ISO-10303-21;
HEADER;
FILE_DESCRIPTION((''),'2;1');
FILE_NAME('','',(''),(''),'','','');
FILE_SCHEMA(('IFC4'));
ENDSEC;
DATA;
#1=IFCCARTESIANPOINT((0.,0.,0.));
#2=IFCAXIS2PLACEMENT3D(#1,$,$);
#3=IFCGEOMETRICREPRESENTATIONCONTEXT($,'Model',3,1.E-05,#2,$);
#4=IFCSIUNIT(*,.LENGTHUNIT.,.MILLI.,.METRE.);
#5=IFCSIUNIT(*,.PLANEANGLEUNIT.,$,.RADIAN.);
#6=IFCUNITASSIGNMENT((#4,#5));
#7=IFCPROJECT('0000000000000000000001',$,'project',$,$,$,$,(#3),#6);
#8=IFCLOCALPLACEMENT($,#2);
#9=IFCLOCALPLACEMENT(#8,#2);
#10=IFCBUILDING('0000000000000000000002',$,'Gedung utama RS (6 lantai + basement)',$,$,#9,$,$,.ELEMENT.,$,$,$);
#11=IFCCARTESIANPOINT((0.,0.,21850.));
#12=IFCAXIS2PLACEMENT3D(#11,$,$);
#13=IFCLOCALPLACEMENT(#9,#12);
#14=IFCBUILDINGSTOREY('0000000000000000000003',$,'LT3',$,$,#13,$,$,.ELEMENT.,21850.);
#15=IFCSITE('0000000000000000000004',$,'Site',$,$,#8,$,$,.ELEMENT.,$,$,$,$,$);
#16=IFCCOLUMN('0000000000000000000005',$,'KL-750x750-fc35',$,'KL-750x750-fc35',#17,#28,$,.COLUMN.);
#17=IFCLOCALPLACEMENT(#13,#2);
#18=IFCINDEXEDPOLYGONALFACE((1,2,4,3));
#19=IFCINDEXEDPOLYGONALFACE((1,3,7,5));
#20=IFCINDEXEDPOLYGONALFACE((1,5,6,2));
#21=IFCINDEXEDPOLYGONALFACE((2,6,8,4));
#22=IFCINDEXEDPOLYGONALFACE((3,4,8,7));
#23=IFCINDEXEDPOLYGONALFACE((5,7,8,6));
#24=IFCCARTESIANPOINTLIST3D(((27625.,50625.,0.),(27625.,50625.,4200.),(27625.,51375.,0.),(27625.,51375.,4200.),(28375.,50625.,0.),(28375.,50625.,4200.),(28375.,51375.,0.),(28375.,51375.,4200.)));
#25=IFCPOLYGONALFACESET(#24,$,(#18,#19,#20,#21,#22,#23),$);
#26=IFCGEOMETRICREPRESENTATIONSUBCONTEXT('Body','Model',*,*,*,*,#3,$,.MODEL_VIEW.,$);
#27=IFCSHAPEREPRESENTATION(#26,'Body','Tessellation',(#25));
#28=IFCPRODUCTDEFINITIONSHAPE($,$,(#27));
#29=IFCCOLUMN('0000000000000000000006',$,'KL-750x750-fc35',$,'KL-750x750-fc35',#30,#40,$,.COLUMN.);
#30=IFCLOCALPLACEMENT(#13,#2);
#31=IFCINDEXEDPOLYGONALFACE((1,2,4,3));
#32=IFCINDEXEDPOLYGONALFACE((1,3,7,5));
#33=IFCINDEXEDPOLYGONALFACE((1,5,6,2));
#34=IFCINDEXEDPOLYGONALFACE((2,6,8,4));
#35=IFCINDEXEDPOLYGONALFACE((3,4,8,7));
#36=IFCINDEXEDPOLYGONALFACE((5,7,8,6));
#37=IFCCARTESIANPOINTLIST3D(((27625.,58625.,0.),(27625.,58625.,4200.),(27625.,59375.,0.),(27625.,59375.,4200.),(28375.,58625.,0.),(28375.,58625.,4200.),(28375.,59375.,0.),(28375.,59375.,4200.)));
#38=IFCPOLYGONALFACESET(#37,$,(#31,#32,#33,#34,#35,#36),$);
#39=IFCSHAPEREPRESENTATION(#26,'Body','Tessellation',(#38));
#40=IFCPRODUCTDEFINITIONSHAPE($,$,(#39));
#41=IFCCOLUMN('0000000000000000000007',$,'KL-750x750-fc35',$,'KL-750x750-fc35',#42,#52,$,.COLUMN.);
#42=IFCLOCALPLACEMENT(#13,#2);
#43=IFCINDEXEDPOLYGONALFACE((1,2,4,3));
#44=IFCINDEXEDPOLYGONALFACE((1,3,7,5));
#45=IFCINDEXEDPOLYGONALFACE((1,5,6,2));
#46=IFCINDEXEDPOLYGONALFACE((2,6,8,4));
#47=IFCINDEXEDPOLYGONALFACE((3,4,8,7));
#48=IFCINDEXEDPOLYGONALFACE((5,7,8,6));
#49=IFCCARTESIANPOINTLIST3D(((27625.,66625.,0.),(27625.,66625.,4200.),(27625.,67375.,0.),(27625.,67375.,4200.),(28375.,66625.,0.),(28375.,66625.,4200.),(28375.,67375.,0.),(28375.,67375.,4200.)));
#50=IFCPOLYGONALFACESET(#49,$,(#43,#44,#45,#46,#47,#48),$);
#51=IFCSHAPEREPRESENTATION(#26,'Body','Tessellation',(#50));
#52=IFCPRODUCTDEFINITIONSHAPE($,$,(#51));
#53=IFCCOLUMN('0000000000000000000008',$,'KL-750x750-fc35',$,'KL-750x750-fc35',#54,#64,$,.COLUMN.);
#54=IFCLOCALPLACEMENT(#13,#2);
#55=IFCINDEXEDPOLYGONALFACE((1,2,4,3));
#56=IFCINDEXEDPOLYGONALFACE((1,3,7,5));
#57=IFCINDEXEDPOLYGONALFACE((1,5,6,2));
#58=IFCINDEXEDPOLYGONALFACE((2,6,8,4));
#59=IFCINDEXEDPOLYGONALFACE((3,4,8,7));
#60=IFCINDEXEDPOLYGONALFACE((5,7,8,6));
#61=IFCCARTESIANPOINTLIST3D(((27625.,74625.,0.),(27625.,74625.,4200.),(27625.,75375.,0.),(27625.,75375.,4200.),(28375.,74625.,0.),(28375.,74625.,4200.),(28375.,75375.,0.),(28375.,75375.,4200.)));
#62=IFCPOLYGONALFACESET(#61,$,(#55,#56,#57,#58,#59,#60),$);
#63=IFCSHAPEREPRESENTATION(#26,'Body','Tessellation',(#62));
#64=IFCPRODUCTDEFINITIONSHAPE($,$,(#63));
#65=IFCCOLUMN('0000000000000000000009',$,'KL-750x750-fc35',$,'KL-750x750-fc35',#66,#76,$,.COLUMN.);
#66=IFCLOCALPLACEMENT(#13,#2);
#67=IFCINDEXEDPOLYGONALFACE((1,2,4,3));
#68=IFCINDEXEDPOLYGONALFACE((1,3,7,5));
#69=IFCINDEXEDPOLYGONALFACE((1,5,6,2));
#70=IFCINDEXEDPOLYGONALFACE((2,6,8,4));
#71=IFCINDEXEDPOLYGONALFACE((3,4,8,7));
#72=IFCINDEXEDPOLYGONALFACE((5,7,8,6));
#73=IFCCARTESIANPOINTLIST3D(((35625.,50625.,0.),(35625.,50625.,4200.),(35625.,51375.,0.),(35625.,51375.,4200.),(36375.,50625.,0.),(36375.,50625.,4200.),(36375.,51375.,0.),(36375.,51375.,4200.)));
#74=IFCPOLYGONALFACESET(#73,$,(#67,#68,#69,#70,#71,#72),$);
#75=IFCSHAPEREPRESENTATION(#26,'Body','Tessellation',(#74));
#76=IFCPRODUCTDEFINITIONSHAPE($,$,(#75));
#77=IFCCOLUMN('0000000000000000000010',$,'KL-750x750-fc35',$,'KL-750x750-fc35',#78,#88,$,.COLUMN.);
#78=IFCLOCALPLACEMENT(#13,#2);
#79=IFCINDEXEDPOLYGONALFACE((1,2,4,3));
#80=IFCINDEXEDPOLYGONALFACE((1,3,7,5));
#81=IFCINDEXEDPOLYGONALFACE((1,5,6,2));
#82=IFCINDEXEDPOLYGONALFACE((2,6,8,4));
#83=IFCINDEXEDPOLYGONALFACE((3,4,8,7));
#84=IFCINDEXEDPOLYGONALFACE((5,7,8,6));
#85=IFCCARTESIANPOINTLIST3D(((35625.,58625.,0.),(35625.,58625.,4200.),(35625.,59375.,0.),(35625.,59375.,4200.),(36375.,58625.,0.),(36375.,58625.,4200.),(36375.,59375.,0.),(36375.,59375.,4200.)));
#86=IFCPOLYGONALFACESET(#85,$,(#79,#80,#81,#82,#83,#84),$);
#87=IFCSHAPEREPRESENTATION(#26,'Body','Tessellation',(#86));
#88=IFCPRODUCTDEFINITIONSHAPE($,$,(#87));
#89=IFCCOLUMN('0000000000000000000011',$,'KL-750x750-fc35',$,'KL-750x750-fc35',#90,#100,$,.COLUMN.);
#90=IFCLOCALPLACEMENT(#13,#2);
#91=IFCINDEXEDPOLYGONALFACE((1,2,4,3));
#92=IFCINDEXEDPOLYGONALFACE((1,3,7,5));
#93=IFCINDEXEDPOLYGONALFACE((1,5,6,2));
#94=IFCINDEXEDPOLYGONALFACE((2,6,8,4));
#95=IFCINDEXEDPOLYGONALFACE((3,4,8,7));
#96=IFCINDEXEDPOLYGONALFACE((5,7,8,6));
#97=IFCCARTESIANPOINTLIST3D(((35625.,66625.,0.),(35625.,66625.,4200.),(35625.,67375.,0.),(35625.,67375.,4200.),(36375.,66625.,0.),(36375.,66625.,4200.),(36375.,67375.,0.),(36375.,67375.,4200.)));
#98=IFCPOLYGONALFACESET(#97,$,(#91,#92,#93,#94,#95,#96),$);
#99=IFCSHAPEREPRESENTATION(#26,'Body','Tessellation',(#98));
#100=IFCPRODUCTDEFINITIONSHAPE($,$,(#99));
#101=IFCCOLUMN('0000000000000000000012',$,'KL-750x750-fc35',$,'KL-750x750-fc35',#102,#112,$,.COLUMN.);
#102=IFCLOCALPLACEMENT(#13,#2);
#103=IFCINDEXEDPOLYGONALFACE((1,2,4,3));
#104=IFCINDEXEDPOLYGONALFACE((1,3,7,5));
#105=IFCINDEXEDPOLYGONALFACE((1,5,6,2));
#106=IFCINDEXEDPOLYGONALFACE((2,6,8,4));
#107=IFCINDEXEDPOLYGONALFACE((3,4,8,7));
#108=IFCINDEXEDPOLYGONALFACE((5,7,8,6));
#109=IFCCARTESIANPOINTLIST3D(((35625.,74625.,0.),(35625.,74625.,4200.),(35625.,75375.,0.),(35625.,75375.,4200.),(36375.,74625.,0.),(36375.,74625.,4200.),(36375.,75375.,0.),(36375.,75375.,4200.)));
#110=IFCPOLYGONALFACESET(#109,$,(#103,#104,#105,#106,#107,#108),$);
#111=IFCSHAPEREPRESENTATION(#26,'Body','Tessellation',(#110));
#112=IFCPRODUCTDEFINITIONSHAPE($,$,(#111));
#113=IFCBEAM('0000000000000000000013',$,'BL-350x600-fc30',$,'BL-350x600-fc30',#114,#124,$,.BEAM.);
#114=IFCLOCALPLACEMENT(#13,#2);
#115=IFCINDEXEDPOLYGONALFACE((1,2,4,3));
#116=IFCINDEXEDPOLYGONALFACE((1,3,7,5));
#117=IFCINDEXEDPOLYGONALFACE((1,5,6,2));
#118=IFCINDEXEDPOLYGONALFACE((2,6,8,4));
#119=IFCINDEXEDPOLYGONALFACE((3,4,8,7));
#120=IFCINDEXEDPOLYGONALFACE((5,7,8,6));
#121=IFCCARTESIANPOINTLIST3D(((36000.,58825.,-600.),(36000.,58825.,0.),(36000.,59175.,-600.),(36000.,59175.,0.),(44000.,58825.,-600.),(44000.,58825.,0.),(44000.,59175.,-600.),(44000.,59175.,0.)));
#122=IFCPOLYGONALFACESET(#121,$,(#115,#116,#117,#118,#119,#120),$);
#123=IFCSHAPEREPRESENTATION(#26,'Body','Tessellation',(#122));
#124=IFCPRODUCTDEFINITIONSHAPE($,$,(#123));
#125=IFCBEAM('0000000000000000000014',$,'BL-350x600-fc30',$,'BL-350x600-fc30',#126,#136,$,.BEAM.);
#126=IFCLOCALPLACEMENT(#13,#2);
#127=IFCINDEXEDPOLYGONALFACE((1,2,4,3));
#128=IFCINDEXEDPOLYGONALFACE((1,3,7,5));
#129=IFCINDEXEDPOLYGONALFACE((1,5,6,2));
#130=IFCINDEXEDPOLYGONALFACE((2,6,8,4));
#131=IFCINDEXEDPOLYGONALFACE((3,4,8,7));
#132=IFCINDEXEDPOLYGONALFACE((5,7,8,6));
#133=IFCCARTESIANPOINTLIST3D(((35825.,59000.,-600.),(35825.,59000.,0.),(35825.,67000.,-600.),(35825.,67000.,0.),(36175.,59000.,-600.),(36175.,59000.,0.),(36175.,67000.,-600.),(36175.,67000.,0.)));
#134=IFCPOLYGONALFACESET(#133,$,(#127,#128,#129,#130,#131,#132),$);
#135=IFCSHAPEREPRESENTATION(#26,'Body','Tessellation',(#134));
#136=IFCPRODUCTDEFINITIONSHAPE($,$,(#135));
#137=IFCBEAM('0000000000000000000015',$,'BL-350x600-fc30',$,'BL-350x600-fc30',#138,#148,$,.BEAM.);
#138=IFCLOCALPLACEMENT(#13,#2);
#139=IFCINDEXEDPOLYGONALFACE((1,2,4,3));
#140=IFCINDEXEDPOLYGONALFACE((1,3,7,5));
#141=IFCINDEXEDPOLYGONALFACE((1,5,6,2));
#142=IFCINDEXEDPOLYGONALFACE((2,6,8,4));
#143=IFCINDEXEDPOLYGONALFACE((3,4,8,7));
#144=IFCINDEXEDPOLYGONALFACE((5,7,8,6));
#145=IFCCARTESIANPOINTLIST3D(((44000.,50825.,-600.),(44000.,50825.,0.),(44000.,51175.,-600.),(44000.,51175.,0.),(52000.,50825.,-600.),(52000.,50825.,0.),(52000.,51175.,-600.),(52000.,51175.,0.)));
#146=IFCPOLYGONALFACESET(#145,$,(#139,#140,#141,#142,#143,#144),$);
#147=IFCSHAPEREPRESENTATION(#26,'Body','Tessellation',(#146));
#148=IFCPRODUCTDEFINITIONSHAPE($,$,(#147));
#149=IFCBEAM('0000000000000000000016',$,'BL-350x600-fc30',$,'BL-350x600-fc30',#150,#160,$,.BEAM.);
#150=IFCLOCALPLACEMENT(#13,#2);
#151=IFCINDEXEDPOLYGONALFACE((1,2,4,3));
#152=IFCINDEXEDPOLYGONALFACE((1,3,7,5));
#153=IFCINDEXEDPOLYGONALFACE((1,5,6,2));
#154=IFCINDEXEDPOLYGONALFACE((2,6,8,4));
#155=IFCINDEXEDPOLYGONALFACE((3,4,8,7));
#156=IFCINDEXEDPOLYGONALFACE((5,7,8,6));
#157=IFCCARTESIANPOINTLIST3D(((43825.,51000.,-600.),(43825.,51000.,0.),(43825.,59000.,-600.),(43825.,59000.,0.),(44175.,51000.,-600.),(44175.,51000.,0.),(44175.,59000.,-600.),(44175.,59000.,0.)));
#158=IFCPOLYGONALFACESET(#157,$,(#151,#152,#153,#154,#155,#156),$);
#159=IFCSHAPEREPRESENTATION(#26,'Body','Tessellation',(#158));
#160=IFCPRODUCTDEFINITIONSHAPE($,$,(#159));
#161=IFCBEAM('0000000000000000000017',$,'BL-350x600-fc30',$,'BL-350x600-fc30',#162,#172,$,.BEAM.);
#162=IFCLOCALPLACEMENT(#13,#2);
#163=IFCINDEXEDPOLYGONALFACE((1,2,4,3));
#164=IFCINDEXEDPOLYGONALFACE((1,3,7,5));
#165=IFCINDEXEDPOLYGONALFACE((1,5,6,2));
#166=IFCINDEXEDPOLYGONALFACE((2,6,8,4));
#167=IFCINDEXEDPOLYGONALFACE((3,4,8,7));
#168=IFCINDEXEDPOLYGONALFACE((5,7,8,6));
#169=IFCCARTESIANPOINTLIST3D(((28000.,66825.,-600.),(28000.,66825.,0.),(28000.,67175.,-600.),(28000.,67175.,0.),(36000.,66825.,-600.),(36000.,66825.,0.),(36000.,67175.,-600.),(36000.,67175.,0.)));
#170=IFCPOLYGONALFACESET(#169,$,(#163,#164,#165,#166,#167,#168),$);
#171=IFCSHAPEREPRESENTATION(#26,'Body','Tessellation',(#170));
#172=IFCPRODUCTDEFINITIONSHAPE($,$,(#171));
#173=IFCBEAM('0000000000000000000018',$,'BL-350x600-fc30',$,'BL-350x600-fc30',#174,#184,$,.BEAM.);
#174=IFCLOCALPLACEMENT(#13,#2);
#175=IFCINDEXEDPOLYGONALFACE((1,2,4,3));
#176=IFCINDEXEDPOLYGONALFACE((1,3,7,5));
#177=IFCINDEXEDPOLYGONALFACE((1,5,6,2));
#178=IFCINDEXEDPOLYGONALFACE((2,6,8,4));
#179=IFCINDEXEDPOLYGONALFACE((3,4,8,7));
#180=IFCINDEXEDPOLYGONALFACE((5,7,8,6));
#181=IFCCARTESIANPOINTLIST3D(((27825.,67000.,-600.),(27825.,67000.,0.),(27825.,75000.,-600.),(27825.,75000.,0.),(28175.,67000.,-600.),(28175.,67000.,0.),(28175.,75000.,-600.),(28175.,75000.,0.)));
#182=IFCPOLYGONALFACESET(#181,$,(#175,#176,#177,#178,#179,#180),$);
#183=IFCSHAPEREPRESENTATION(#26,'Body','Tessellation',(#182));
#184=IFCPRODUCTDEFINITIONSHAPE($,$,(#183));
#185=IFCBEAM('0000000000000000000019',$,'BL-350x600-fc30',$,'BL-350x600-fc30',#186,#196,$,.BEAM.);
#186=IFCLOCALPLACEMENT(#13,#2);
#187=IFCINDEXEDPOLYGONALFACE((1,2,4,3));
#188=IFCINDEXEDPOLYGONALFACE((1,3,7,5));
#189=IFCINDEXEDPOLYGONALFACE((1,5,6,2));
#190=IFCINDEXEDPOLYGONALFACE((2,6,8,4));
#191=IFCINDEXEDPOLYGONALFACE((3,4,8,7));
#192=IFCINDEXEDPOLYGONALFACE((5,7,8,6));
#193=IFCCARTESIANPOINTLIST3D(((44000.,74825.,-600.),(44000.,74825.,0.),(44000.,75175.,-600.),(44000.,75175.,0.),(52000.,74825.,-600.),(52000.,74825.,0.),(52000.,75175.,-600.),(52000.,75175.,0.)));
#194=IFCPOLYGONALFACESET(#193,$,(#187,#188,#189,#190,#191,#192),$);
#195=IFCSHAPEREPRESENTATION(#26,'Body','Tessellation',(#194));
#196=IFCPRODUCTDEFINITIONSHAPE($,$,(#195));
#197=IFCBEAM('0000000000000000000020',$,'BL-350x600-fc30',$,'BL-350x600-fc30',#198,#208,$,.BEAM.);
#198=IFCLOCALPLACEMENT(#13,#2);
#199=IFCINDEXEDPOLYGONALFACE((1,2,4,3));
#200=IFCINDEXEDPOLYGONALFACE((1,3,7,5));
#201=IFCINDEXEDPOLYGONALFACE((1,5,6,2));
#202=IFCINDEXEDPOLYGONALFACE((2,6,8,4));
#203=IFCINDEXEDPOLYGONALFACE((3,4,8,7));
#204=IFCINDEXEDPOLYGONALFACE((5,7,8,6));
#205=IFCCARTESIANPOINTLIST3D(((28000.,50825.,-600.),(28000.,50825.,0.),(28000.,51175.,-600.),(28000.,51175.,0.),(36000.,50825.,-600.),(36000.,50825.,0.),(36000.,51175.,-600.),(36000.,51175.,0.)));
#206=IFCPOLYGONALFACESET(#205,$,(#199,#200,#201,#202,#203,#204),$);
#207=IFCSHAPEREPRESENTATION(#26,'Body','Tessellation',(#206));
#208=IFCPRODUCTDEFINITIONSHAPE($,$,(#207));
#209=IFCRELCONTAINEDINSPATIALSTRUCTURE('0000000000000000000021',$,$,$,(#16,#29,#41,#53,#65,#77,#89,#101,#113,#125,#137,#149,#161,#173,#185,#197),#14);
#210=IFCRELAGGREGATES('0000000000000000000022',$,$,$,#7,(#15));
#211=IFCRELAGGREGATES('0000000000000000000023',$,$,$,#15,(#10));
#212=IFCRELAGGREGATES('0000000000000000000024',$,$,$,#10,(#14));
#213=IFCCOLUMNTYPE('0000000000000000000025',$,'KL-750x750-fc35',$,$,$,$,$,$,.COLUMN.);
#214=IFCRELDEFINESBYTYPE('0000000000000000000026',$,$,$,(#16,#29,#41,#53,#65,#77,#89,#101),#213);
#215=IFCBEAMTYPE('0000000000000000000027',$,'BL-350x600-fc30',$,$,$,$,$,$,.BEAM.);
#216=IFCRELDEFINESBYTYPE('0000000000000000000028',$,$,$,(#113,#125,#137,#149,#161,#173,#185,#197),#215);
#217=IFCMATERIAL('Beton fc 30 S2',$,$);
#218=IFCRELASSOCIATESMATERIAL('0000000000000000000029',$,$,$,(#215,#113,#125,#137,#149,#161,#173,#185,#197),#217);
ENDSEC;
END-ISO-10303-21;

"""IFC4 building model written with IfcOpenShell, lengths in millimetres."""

from ifc_helpers import new_model, si_unit, frame, origin, origin_2d, place, context, subcontext, project, spatial, rectangle, extrude, material, material_profile, profile_set, profile_usage, type_object, element, save


model = new_model("IFC4")

# Units and contexts
model_context = context("Model", 3, precision=1e-05, world=origin())
body_context = subcontext(model_context, "Body", "Model", "MODEL_VIEW")
ifc_project = project(units=[si_unit("LENGTHUNIT", "METRE", prefix="MILLI"), si_unit("PLANEANGLEUNIT", "RADIAN")], contexts=[model_context])

# Site, building, storey
site_placement = place(None, origin())
site = spatial("IfcSite", under=ifc_project, at=site_placement, Name="Site", CompositionType="ELEMENT")
building_placement = place(site_placement, origin())
building = spatial("IfcBuilding", under=site, at=building_placement, Name="Gedung utama RS (6 lantai + basement)", CompositionType="ELEMENT")
storey_placement = place(building_placement, frame((0.0, 0.0, 21850.0)))
storey = spatial("IfcBuildingStorey", under=building, at=storey_placement, Name="LT3", CompositionType="ELEMENT", Elevation=21850.0)

# Columns
ifc_material_profile_1 = material_profile(None, rectangle(XDim=750.0, YDim=750.0, at=origin_2d()), Name="KL-750x750-fc35")
ifc_profile_set_1 = profile_set([ifc_material_profile_1], Name="KL-750x750-fc35")
ifc_profile_usage_1 = profile_usage(ifc_profile_set_1, cardinal=5)
column_type = type_object("IfcColumnType", Name="KL-750x750-fc35", PredefinedType="COLUMN", material=ifc_profile_set_1)
for number, where, z_axis, x_axis, name in (
    (1, (28000.0, 51000.0, 0.0), (0.0, 0.0, 1.0), (1.0, 0.0, 0.0), "KL-750x750-fc35"),
    (2, (28000.0, 59000.0, 0.0), (0.0, 0.0, 1.0), (1.0, 0.0, 0.0), "KL-750x750-fc35"),
    (3, (28000.0, 67000.0, 0.0), (0.0, 0.0, 1.0), (1.0, 0.0, 0.0), "KL-750x750-fc35"),
    (4, (28000.0, 75000.0, 0.0), (0.0, 0.0, 1.0), (1.0, 0.0, 0.0), "KL-750x750-fc35"),
    (5, (36000.0, 51000.0, 0.0), (0.0, 0.0, 1.0), (1.0, 0.0, 0.0), "KL-750x750-fc35"),
    (6, (36000.0, 59000.0, 0.0), (0.0, 0.0, 1.0), (1.0, 0.0, 0.0), "KL-750x750-fc35"),
    (7, (36000.0, 67000.0, 0.0), (0.0, 0.0, 1.0), (1.0, 0.0, 0.0), "KL-750x750-fc35"),
    (8, (36000.0, 75000.0, 0.0), (0.0, 0.0, 1.0), (1.0, 0.0, 0.0), "KL-750x750-fc35"),
):
    element("IfcColumn", number, at=place(storey_placement, frame(where, z_axis=z_axis, x_axis=x_axis)), inside=storey, type_object=column_type, material=ifc_profile_usage_1, Name=name, ObjectType="KL-750x750-fc35", PredefinedType="COLUMN", context=body_context, shape_type="SweptSolid", body=[
        extrude(rectangle(XDim=750.0, YDim=750.0, at=origin_2d()), origin(), (0.0, 0.0, 1.0), 4200.0),
    ])

# Beams
ifc_material = material(Name="Beton fc 30 S2")
ifc_material_profile_2 = material_profile(ifc_material, rectangle(XDim=350.0, YDim=600.0, at=origin_2d()), Name="BL-350x600-fc30")
ifc_profile_set_2 = profile_set([ifc_material_profile_2], Name="BL-350x600-fc30")
ifc_profile_usage_2 = profile_usage(ifc_profile_set_2, cardinal=8)
beam_type = type_object("IfcBeamType", Name="BL-350x600-fc30", PredefinedType="BEAM", material=ifc_profile_set_2)
beam_1_placement = place(storey_placement, frame((36000.0, 59000.0, -300.0)))
element("IfcBeam", 9, at=beam_1_placement, inside=storey, type_object=beam_type, material=ifc_profile_usage_2, Name="BL-350x600-fc30", ObjectType="BL-350x600-fc30", PredefinedType="BEAM", context=body_context, shape_type="SweptSolid", body=[
    extrude(rectangle(XDim=350.0, YDim=600.0, at=origin_2d()), frame((0.0, 0.0, 0.0), z_axis=(1.0, 0.0, 0.0), x_axis=(0.0, 1.0, 0.0)), (0.0, 0.0, 1.0), 8000.0),
])
beam_2_placement = place(storey_placement, frame((36000.0, 59000.0, -300.0)))
element("IfcBeam", 10, at=beam_2_placement, inside=storey, type_object=beam_type, material=ifc_profile_usage_2, Name="BL-350x600-fc30", ObjectType="BL-350x600-fc30", PredefinedType="BEAM", context=body_context, shape_type="SweptSolid", body=[
    extrude(rectangle(XDim=350.0, YDim=600.0, at=origin_2d()), frame((0.0, 0.0, 0.0), z_axis=(0.0, 1.0, 0.0), x_axis=(-1.0, 0.0, 0.0)), (0.0, 0.0, 1.0), 8000.0),
])
beam_3_placement = place(storey_placement, frame((44000.0, 51000.0, -300.0)))
element("IfcBeam", 11, at=beam_3_placement, inside=storey, type_object=beam_type, material=ifc_profile_usage_2, Name="BL-350x600-fc30", ObjectType="BL-350x600-fc30", PredefinedType="BEAM", context=body_context, shape_type="SweptSolid", body=[
    extrude(rectangle(XDim=350.0, YDim=600.0, at=origin_2d()), frame((0.0, 0.0, 0.0), z_axis=(1.0, 0.0, 0.0), x_axis=(0.0, 1.0, 0.0)), (0.0, 0.0, 1.0), 8000.0),
])
beam_4_placement = place(storey_placement, frame((44000.0, 51000.0, -300.0)))
element("IfcBeam", 12, at=beam_4_placement, inside=storey, type_object=beam_type, material=ifc_profile_usage_2, Name="BL-350x600-fc30", ObjectType="BL-350x600-fc30", PredefinedType="BEAM", context=body_context, shape_type="SweptSolid", body=[
    extrude(rectangle(XDim=350.0, YDim=600.0, at=origin_2d()), frame((0.0, 0.0, 0.0), z_axis=(0.0, 1.0, 0.0), x_axis=(-1.0, 0.0, 0.0)), (0.0, 0.0, 1.0), 8000.0),
])
beam_5_placement = place(storey_placement, frame((28000.0, 67000.0, -300.0)))
element("IfcBeam", 13, at=beam_5_placement, inside=storey, type_object=beam_type, material=ifc_profile_usage_2, Name="BL-350x600-fc30", ObjectType="BL-350x600-fc30", PredefinedType="BEAM", context=body_context, shape_type="SweptSolid", body=[
    extrude(rectangle(XDim=350.0, YDim=600.0, at=origin_2d()), frame((0.0, 0.0, 0.0), z_axis=(1.0, 0.0, 0.0), x_axis=(0.0, 1.0, 0.0)), (0.0, 0.0, 1.0), 8000.0),
])
beam_6_placement = place(storey_placement, frame((28000.0, 67000.0, -300.0)))
element("IfcBeam", 14, at=beam_6_placement, inside=storey, type_object=beam_type, material=ifc_profile_usage_2, Name="BL-350x600-fc30", ObjectType="BL-350x600-fc30", PredefinedType="BEAM", context=body_context, shape_type="SweptSolid", body=[
    extrude(rectangle(XDim=350.0, YDim=600.0, at=origin_2d()), frame((0.0, 0.0, 0.0), z_axis=(0.0, 1.0, 0.0), x_axis=(-1.0, 0.0, 0.0)), (0.0, 0.0, 1.0), 8000.0),
])
for number, where, name in (
    (15, (44000.0, 75000.0, -300.0), "BL-350x600-fc30"),
    (16, (28000.0, 51000.0, -300.0), "BL-350x600-fc30"),
):
    element("IfcBeam", number, at=place(storey_placement, frame(where)), inside=storey, type_object=beam_type, material=ifc_profile_usage_2, Name=name, ObjectType="BL-350x600-fc30", PredefinedType="BEAM", context=body_context, shape_type="SweptSolid", body=[
        extrude(rectangle(XDim=350.0, YDim=600.0, at=origin_2d()), frame((0.0, 0.0, 0.0), z_axis=(1.0, 0.0, 0.0), x_axis=(0.0, 1.0, 0.0)), (0.0, 0.0, 1.0), 8000.0),
    ])

save(model, "model.ifc")
